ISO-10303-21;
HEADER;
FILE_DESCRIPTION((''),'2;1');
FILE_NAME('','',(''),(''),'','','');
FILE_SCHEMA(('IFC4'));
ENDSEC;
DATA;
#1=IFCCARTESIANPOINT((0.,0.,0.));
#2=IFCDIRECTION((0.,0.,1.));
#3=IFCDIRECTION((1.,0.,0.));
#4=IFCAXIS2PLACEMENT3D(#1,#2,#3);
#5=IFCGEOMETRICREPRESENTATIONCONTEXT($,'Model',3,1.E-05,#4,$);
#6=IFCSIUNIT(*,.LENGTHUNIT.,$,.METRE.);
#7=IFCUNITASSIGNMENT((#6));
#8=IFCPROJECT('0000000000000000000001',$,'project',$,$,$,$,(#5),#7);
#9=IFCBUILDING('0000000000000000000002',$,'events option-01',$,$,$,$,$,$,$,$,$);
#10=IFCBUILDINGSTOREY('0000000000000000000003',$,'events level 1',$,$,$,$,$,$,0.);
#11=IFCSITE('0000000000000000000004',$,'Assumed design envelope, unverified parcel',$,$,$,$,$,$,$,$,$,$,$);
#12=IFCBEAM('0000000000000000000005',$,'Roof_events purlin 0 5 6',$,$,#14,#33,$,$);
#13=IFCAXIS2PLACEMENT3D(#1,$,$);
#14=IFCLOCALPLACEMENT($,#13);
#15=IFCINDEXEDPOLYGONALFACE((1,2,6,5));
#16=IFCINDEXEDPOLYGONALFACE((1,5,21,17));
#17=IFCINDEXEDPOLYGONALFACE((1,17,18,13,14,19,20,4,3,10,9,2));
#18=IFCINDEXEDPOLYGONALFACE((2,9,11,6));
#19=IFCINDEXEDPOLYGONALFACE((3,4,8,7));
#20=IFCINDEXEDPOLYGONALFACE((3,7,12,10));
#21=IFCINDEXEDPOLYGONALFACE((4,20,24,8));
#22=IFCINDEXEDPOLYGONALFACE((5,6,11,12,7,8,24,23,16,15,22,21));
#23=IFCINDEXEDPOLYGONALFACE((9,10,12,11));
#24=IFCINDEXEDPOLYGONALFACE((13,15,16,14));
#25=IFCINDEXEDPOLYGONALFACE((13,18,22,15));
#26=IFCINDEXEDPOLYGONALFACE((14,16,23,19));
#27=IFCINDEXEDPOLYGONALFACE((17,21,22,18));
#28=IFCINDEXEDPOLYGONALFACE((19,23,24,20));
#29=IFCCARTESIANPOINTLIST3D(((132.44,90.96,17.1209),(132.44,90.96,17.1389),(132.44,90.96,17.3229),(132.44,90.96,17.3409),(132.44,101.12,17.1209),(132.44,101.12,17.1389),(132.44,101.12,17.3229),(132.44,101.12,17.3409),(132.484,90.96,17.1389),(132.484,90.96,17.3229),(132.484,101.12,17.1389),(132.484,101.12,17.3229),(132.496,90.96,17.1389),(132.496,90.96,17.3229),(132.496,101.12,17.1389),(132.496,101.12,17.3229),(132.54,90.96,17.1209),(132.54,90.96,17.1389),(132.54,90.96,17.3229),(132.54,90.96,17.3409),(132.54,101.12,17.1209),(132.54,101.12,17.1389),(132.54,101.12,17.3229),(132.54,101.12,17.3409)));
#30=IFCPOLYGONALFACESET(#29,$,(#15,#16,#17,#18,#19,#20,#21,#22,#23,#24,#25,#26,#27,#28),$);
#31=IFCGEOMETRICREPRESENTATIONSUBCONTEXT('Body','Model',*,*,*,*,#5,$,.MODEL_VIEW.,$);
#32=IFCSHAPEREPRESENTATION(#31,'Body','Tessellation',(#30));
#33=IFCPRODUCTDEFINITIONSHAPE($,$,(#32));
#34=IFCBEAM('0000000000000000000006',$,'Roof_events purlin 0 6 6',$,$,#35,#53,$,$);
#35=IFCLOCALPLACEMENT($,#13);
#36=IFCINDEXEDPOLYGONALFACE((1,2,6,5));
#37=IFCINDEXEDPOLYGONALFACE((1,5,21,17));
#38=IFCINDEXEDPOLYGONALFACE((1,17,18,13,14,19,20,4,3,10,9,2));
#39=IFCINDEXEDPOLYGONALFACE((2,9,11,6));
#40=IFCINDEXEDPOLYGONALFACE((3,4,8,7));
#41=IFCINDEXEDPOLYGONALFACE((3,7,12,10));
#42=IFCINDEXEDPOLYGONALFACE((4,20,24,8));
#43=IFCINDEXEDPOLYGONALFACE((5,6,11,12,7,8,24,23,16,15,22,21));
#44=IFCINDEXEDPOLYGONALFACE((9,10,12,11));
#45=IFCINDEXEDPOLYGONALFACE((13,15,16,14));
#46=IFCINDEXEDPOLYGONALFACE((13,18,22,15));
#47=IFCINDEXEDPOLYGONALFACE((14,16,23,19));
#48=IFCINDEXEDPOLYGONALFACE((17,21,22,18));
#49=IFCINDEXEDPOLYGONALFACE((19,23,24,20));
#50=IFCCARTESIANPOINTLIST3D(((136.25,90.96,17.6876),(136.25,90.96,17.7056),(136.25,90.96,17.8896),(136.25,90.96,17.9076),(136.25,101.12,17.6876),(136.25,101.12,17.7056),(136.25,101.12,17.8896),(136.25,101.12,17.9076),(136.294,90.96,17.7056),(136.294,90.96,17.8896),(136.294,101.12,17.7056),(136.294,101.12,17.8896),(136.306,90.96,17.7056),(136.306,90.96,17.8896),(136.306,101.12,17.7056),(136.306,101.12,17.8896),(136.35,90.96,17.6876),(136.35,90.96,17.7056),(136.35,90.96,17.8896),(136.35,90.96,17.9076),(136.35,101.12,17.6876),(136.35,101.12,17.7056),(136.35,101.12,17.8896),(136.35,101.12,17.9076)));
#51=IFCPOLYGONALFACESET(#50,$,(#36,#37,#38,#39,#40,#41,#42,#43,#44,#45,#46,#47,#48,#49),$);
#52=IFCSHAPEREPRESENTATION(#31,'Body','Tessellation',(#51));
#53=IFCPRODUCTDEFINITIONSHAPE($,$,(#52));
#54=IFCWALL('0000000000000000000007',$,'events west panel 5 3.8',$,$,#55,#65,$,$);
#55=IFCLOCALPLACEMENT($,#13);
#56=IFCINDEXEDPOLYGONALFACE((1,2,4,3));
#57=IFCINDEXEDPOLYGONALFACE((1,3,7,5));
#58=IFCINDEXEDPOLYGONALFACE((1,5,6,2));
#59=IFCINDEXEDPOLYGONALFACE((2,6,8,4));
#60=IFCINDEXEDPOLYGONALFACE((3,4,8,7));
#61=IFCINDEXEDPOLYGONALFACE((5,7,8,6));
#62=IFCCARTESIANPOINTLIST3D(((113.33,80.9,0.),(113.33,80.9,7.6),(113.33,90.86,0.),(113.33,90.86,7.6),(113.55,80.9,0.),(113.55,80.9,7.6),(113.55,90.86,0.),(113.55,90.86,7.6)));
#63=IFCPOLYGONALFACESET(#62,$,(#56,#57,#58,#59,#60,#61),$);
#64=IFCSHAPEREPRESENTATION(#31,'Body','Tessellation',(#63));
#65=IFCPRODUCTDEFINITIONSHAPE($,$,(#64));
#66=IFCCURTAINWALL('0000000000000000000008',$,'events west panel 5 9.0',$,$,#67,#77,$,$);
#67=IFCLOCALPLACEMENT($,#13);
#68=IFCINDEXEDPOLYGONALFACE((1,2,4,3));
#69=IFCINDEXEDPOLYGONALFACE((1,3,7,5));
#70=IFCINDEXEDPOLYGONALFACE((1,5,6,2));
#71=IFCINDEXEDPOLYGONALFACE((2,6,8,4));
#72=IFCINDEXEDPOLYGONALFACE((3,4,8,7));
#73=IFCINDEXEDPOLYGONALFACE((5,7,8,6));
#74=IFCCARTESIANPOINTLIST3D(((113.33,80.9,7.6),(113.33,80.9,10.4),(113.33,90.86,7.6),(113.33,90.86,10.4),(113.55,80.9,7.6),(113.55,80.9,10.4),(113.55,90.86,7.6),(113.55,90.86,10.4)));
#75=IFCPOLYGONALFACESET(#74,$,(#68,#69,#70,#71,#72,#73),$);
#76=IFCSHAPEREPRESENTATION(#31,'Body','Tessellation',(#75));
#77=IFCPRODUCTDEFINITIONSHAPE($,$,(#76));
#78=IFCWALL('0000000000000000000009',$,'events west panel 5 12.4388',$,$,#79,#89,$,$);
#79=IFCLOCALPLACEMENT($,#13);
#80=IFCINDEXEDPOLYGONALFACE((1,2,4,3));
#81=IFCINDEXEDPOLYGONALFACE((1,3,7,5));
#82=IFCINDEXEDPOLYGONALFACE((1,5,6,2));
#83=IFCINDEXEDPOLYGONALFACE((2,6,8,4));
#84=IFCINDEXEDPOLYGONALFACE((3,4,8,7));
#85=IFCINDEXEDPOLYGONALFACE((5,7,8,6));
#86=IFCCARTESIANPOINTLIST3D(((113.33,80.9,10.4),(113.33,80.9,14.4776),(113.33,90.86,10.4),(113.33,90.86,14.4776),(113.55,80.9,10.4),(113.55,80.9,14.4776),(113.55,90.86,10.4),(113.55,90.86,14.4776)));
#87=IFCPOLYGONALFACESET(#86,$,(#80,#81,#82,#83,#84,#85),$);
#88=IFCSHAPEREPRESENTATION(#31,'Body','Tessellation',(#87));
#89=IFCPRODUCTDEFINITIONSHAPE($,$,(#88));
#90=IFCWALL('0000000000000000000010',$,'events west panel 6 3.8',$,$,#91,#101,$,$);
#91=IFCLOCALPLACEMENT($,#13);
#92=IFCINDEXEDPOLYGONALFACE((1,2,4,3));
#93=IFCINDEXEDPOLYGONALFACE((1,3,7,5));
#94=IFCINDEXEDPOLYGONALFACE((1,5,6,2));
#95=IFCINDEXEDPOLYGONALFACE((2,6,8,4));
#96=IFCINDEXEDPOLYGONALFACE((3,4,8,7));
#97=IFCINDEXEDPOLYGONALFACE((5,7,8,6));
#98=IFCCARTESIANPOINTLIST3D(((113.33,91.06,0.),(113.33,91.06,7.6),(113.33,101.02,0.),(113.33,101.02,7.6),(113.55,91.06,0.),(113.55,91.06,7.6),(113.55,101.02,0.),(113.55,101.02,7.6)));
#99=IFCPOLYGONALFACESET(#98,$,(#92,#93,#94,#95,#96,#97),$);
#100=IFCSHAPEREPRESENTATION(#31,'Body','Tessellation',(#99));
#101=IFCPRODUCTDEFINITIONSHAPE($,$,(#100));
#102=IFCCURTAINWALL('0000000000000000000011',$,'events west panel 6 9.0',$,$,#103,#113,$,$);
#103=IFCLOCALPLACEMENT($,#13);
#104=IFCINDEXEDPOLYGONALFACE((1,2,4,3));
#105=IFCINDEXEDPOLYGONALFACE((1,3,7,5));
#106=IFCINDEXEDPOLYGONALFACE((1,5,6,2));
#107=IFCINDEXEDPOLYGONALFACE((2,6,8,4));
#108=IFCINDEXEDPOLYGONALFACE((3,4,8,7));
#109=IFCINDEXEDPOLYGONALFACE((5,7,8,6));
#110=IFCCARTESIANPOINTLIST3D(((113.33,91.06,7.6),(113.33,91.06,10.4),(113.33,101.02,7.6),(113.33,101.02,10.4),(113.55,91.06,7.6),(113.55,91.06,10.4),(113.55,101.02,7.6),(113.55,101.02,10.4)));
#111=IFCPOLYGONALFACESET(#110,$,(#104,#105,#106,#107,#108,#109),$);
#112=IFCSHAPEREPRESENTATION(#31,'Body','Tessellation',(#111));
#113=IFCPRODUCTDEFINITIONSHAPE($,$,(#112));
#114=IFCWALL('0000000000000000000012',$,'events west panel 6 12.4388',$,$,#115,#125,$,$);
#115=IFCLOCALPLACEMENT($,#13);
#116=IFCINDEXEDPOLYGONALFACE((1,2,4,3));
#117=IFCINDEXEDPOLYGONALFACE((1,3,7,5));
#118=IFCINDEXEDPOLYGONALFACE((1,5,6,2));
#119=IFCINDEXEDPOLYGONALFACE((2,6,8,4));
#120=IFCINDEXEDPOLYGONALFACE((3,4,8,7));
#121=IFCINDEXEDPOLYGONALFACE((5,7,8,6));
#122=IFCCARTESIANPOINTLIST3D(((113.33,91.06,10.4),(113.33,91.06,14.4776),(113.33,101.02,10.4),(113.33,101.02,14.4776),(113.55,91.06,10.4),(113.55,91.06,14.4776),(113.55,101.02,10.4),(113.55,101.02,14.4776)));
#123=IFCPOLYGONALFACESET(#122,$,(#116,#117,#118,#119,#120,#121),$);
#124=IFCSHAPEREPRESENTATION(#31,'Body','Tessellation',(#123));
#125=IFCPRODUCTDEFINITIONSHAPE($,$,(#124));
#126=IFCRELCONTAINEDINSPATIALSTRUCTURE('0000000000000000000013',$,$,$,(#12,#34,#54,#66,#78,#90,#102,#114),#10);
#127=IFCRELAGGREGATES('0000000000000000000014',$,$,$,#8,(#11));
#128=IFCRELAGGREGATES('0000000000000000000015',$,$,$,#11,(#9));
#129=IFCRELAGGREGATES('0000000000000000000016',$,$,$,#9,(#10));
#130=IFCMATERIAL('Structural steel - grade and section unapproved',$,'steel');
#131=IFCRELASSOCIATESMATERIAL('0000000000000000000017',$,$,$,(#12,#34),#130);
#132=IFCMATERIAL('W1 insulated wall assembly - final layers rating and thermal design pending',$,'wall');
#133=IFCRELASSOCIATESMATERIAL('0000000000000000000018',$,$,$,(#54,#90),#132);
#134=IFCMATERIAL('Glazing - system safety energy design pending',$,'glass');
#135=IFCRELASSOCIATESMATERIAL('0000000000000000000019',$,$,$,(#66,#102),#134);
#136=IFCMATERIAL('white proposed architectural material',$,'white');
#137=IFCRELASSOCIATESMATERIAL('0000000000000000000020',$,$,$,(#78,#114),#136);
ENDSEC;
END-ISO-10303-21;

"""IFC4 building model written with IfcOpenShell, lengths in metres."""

from ifc_helpers import new_model, si_unit, frame, origin_with_axes, place, context, subcontext, project, spatial, rectangle, i_section, extrude, material, element, save


model = new_model("IFC4")

# Units and contexts
model_context = context("Model", 3, precision=1e-05, world=origin_with_axes())
body_context = subcontext(model_context, "Body", "Model", "MODEL_VIEW")
ifc_project = project(units=[si_unit("LENGTHUNIT", "METRE")], contexts=[model_context])

# Site, building, storey
site = spatial("IfcSite", under=ifc_project, Name="Assumed design envelope, unverified parcel")
building = spatial("IfcBuilding", under=site, Name="events option-01")
storey = spatial("IfcBuildingStorey", under=building, Name="events level 1", Elevation=0.0)

# Shared definitions
ifc_material_1 = material(Name="Structural steel - grade and section unapproved", Category="steel")

# Beams
for number, where, z_axis, x_axis, name in (
    (1, (132.49, 90.96, 17.2309), (0.0, 1.0, 0.0), (-1.0, 0.0, 0.0), "Roof_events purlin 0 5 6"),
    (2, (136.3, 90.96, 17.7976), (0.0, 1.0, 0.0), (-1.0, 0.0, 0.0), "Roof_events purlin 0 6 6"),
):
    element("IfcBeam", number, at=place(None, frame(where, z_axis=z_axis, x_axis=x_axis)), inside=storey, material=ifc_material_1, Name=name, context=body_context, shape_type="SweptSolid", body=[
        extrude(i_section(OverallWidth=0.1, OverallDepth=0.22, WebThickness=0.012, FlangeThickness=0.018, FilletRadius=0.0), origin_with_axes(), (0.0, 0.0, 1.0), 10.16),
    ])

# Wall
ifc_material_2 = material(Name="W1 insulated wall assembly - final layers rating and thermal design pending", Category="wall")
wall_1_placement = place(None, frame((113.44, 85.88, 0.0), z_axis=(0.0, 0.0, 1.0), x_axis=(1.0, 0.0, 0.0)))
element("IfcWall", 3, at=wall_1_placement, inside=storey, material=ifc_material_2, Name="events west panel 5 3.8", context=body_context, shape_type="SweptSolid", body=[
    extrude(rectangle(XDim=0.22, YDim=9.96), origin_with_axes(), (0.0, 0.0, 1.0), 7.6),
])

# Curtain wall
ifc_material_3 = material(Name="Glazing - system safety energy design pending", Category="glass")
curtain_wall_1_placement = place(None, frame((113.44, 85.88, 7.6), z_axis=(0.0, 0.0, 1.0), x_axis=(1.0, 0.0, 0.0)))
element("IfcCurtainWall", 4, at=curtain_wall_1_placement, inside=storey, material=ifc_material_3, Name="events west panel 5 9.0", context=body_context, shape_type="SweptSolid", body=[
    extrude(rectangle(XDim=0.22, YDim=9.96), origin_with_axes(), (0.0, 0.0, 1.0), 2.8),
])

# Walls
ifc_material_4 = material(Name="white proposed architectural material", Category="white")
wall_2_placement = place(None, frame((113.44, 85.88, 10.4), z_axis=(0.0, 0.0, 1.0), x_axis=(1.0, 0.0, 0.0)))
element("IfcWall", 5, at=wall_2_placement, inside=storey, material=ifc_material_4, Name="events west panel 5 12.4388", context=body_context, shape_type="SweptSolid", body=[
    extrude(rectangle(XDim=0.22, YDim=9.96), origin_with_axes(), (0.0, 0.0, 1.0), 4.0776),
])
wall_3_placement = place(None, frame((113.44, 96.04, 0.0), z_axis=(0.0, 0.0, 1.0), x_axis=(1.0, 0.0, 0.0)))
element("IfcWall", 6, at=wall_3_placement, inside=storey, material=ifc_material_2, Name="events west panel 6 3.8", context=body_context, shape_type="SweptSolid", body=[
    extrude(rectangle(XDim=0.22, YDim=9.96), origin_with_axes(), (0.0, 0.0, 1.0), 7.6),
])

# Curtain wall
curtain_wall_2_placement = place(None, frame((113.44, 96.04, 7.6), z_axis=(0.0, 0.0, 1.0), x_axis=(1.0, 0.0, 0.0)))
element("IfcCurtainWall", 7, at=curtain_wall_2_placement, inside=storey, material=ifc_material_3, Name="events west panel 6 9.0", context=body_context, shape_type="SweptSolid", body=[
    extrude(rectangle(XDim=0.22, YDim=9.96), origin_with_axes(), (0.0, 0.0, 1.0), 2.8),
])

# Wall
wall_4_placement = place(None, frame((113.44, 96.04, 10.4), z_axis=(0.0, 0.0, 1.0), x_axis=(1.0, 0.0, 0.0)))
element("IfcWall", 8, at=wall_4_placement, inside=storey, material=ifc_material_4, Name="events west panel 6 12.4388", context=body_context, shape_type="SweptSolid", body=[
    extrude(rectangle(XDim=0.22, YDim=9.96), origin_with_axes(), (0.0, 0.0, 1.0), 4.0776),
])

save(model, "model.ifc")
